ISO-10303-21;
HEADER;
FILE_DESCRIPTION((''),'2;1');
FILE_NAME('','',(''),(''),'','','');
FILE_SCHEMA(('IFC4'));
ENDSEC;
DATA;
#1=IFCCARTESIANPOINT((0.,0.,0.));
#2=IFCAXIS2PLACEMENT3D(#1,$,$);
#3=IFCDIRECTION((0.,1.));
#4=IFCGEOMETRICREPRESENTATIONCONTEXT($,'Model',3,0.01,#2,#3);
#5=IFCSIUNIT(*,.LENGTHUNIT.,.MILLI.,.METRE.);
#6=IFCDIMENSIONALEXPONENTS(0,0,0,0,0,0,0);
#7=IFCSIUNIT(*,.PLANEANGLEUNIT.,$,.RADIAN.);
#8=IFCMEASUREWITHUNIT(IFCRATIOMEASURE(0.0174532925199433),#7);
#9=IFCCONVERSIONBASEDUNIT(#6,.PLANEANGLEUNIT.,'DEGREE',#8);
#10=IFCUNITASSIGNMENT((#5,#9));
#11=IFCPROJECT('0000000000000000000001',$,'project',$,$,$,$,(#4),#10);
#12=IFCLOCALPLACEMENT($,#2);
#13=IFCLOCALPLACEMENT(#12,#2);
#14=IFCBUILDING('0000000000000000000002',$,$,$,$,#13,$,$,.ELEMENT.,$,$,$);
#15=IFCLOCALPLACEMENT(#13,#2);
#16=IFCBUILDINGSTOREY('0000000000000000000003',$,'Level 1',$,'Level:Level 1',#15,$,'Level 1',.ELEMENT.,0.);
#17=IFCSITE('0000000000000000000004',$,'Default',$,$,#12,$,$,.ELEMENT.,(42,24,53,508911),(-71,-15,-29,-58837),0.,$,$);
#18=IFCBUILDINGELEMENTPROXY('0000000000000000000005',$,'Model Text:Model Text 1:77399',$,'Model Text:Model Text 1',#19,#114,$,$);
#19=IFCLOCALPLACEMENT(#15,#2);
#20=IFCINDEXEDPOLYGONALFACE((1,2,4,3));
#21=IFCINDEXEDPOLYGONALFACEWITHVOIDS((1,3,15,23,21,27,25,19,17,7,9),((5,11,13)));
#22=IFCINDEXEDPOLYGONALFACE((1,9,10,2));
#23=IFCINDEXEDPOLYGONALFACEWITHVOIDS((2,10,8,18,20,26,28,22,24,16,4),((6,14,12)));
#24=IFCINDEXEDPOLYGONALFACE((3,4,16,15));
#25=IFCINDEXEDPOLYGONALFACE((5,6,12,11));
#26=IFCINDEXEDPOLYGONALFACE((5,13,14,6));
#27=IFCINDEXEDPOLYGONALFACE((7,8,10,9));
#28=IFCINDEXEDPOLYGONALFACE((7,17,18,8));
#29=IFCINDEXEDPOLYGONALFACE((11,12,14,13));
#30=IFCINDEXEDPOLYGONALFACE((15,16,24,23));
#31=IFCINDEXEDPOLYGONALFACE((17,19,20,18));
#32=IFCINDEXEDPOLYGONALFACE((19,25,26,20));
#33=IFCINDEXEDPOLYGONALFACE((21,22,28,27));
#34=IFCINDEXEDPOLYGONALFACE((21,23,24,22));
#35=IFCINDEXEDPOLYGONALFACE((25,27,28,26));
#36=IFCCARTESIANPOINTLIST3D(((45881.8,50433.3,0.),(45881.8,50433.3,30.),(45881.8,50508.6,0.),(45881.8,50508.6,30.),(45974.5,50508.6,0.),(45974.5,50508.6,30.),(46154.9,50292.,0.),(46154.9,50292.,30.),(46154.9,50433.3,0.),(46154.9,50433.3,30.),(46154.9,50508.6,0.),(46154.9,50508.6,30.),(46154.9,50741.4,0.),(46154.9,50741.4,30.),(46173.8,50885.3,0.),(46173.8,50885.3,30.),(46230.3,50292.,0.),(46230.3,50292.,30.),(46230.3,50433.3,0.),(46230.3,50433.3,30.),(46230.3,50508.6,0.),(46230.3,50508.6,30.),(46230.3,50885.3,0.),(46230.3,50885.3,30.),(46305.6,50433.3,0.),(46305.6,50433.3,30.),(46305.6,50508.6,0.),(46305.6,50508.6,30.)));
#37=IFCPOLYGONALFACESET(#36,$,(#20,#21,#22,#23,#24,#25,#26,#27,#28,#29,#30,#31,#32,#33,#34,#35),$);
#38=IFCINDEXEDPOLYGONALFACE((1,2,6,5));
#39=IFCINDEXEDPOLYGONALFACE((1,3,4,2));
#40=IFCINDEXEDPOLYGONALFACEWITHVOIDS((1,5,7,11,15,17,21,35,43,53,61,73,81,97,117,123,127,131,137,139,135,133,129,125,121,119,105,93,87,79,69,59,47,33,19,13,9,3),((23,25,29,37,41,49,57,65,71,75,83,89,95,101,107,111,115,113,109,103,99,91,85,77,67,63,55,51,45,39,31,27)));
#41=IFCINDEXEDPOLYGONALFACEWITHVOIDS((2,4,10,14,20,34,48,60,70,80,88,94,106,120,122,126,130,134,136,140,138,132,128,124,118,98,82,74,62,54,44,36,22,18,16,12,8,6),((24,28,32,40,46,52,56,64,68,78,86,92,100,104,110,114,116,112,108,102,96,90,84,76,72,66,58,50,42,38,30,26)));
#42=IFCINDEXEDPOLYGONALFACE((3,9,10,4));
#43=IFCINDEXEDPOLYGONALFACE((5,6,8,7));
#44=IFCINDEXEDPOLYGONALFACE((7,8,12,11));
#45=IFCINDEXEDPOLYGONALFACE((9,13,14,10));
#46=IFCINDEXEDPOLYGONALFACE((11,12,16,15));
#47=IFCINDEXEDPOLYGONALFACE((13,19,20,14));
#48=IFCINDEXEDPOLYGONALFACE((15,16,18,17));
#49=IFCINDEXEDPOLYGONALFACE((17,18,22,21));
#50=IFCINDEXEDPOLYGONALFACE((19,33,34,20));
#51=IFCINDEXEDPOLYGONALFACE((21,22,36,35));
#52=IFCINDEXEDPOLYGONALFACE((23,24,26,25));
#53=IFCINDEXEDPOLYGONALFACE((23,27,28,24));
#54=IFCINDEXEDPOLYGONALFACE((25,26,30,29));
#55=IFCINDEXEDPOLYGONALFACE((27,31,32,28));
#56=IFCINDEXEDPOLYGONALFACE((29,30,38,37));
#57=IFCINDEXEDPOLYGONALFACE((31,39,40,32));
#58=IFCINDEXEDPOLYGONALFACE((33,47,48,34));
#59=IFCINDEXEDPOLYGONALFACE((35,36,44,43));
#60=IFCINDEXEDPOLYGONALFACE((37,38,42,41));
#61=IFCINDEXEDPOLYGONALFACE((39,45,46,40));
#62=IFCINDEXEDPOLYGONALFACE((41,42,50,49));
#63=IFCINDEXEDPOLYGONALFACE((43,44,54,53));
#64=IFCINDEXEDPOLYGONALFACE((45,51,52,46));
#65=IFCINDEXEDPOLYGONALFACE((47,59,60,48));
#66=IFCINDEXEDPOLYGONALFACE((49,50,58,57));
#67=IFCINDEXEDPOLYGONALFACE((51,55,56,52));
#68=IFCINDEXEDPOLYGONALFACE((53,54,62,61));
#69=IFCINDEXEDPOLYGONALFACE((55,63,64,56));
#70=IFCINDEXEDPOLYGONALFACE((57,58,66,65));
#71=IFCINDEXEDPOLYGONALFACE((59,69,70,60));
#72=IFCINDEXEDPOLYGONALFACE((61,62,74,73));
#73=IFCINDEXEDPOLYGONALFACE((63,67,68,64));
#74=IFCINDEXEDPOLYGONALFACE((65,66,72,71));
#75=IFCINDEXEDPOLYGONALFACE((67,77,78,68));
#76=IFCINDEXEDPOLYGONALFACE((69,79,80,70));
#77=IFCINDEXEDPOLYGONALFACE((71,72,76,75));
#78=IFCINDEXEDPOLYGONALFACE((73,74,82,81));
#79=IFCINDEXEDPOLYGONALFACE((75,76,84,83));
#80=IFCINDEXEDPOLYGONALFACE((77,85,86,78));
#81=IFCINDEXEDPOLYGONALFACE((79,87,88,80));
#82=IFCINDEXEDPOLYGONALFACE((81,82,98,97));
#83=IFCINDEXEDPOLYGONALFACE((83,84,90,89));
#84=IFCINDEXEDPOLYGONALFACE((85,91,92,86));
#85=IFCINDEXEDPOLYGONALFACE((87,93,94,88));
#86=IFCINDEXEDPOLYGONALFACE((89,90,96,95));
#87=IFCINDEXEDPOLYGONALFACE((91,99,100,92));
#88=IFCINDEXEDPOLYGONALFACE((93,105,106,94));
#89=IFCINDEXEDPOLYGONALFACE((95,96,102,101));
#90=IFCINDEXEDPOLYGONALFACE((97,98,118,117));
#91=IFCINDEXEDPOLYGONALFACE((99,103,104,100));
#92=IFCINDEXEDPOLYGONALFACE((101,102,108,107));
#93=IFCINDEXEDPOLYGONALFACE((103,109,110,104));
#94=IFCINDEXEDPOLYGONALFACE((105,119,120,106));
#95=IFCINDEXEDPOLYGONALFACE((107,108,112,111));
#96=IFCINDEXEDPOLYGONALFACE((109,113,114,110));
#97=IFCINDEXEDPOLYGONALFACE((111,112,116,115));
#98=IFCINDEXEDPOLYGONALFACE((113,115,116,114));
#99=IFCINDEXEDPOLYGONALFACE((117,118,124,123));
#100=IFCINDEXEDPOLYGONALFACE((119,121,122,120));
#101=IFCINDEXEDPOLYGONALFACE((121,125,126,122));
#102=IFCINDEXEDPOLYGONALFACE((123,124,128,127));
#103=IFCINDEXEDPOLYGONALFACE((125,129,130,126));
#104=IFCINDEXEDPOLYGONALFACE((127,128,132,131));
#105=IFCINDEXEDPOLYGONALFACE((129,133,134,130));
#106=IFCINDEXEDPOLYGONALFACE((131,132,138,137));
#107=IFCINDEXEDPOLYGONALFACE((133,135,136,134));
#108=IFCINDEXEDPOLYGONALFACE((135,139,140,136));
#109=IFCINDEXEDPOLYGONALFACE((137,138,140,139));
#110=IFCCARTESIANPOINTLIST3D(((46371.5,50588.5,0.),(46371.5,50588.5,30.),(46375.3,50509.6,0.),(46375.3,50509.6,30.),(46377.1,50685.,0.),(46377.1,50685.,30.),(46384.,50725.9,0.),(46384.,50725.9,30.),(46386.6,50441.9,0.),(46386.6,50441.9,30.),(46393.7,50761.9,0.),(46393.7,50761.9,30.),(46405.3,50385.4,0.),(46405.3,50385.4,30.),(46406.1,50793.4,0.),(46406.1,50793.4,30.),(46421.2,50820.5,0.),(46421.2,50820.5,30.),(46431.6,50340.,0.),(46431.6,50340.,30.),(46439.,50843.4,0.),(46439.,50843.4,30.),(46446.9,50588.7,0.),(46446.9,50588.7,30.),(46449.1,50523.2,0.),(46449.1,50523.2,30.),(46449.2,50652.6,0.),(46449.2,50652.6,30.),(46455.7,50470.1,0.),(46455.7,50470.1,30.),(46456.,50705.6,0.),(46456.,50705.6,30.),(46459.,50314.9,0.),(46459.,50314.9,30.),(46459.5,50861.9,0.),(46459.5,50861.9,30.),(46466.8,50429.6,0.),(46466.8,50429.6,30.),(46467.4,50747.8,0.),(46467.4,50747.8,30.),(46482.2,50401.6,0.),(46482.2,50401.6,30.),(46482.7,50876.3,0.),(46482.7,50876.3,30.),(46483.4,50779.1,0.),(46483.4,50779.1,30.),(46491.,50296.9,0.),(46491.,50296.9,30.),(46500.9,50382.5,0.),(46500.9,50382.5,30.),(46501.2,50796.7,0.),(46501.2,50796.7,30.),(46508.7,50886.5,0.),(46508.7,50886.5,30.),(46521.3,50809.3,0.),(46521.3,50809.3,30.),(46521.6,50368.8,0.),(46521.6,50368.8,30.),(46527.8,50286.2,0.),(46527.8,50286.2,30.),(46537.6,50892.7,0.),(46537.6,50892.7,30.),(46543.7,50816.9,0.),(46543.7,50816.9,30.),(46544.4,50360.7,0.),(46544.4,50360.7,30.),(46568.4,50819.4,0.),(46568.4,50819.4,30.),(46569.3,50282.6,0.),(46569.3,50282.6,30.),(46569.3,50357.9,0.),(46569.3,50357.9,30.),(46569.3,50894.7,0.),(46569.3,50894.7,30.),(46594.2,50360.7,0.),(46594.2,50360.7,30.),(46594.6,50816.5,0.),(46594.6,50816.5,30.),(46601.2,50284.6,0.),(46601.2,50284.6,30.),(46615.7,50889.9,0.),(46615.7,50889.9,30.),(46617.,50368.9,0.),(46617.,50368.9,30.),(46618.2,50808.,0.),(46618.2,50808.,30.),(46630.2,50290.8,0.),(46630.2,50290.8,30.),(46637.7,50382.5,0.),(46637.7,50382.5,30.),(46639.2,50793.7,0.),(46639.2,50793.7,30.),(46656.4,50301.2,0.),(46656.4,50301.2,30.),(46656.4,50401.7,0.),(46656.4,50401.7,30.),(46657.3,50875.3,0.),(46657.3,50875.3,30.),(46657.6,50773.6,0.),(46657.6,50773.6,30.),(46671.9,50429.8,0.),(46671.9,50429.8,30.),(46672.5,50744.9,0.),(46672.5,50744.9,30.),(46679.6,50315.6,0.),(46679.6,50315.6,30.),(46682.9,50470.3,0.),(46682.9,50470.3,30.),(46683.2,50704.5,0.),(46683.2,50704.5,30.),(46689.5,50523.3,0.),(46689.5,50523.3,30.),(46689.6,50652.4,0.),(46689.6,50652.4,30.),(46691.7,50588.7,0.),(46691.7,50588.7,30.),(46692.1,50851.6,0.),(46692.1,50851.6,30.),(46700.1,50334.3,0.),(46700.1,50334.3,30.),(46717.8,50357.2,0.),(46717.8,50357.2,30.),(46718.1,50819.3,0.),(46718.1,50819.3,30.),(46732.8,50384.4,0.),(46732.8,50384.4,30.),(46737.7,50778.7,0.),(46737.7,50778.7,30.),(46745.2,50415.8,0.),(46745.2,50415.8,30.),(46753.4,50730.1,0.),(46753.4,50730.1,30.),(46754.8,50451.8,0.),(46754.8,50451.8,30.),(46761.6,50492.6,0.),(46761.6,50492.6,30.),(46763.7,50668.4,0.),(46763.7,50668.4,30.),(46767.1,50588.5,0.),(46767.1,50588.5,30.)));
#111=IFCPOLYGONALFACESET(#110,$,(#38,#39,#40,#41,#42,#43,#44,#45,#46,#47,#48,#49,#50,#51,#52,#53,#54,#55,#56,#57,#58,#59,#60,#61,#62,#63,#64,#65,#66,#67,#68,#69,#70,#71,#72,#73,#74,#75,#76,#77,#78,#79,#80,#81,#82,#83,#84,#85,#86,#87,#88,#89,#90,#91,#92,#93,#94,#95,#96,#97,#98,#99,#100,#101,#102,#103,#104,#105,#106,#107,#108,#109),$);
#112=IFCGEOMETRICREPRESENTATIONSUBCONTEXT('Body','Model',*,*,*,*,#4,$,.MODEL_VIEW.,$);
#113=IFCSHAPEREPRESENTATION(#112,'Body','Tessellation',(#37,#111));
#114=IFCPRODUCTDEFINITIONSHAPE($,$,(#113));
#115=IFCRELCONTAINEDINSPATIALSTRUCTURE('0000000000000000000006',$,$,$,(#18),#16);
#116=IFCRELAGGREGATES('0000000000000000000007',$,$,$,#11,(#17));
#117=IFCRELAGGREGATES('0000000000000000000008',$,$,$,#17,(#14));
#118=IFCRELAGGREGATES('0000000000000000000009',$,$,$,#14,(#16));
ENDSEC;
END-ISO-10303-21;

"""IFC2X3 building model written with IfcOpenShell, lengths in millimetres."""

from ifc_helpers import new_model, entity, si_unit, converted_unit, direction, frame, origin, place, context, subcontext, project, spatial, polyline, outline, extrude, element, save


model = new_model("IFC2X3")

# Units and contexts
model_context = context("Model", 3, precision=0.01, world=origin(), true_north=direction((0.0, 1.0)))
body_context = subcontext(model_context, "Body", "Model", "MODEL_VIEW")
ifc_project = project(units=[si_unit("LENGTHUNIT", "METRE", prefix="MILLI"), converted_unit("PLANEANGLEUNIT", "DEGREE", entity("IfcRatioMeasure", 0.0174532925199433), si_unit("PLANEANGLEUNIT", "RADIAN"), dimensions=[0, 0, 0, 0, 0, 0, 0])], contexts=[model_context])

# Site, building, storey
site_placement = place(None, origin())
site = spatial("IfcSite", under=ifc_project, at=site_placement, Name="Default", CompositionType="ELEMENT", RefLatitude=(42, 24, 53, 508911), RefLongitude=(-71, -15, -29, -58837), RefElevation=0.0)
building_placement = place(site_placement, origin())
building = spatial("IfcBuilding", under=site, at=building_placement, CompositionType="ELEMENT")
storey_placement = place(building_placement, origin())
storey = spatial("IfcBuildingStorey", under=building, at=storey_placement, Name="Level 1", ObjectType="Level:Level 1", LongName="Level 1", CompositionType="ELEMENT", Elevation=0.0)

# Building element proxy
proxy_1_placement = place(storey_placement, origin())
element("IfcBuildingElementProxy", 1, at=proxy_1_placement, inside=storey, Name="Model Text:Model Text 1:77399", ObjectType="Model Text:Model Text 1", context=body_context, shape_type="SweptSolid", body=[
    extrude(outline(polyline([(-6.8, -218.3), (68.5, -218.3), (68.5, -77.1), (143.8, -77.1), (143.8, -1.7), (68.5, -1.7), (68.5, 375.0), (12.0, 375.0), (-280.0, -1.7), (-280.0, -77.1), (-6.8, -77.1), (-6.8, -218.3)]), holes=[polyline([(-6.8, -1.7), (-187.3, -1.7), (-6.8, 231.1), (-6.8, -1.7)])]), frame((46161.8, 50510.3, 0.0)), (0.0, 0.0, 1.0), 30.0),
    extrude(outline(polyline([(-10.6, -198.7), (68.3, -198.7), (136.5, -190.7), (193.9, -174.7), (240.5, -150.6), (266.9, -124.4), (286.3, -93.2), (298.8, -57.0), (304.3, -15.7), (303.8, 16.2), (299.0, 45.5), (289.9, 72.1), (276.6, 96.0), (258.9, 117.3), (236.9, 136.2), (210.4, 152.5), (179.6, 166.3), (144.1, 177.6), (103.7, 186.3), (8.2, 196.4), (-71.8, 196.7), (-134.0, 189.4), (-183.3, 176.1), (-224.7, 158.4), (-258.2, 133.9), (-283.5, 100.3), (-300.1, 59.5), (-307.1, 13.4), (-306.6, -18.4), (-301.8, -47.5), (-292.8, -74.0), (-279.6, -97.9), (-262.0, -119.2), (-240.0, -138.1), (-213.6, -154.5), (-182.8, -168.4), (-147.3, -179.8), (-106.7, -188.6), (-10.6, -198.7)]), holes=[polyline([(-7.2, -123.5), (-71.0, -118.2), (-123.6, -108.8), (-165.2, -95.4), (-195.7, -78.0), (-212.4, -59.4), (-224.1, -38.7), (-230.6, -15.9), (-231.9, 8.9), (-227.8, 35.0), (-218.1, 58.1), (-202.8, 78.4), (-182.0, 95.8), (-152.6, 109.4), (-111.7, 118.1), (-59.4, 122.0), (4.4, 121.1), (69.6, 115.8), (122.2, 106.7), (162.2, 93.7), (189.5, 77.0), (207.7, 57.4), (220.4, 36.0), (227.5, 12.8), (229.1, -12.1), (225.2, -36.8), (215.9, -59.2), (201.3, -79.3), (181.4, -97.1), (152.6, -111.2), (111.6, -120.3), (58.3, -124.4), (-7.2, -123.5)])]), frame((46570.6, 50587.3, 0.0), z_axis=(0.0, 0.0, 1.0), x_axis=(0.047515, -0.998871, 0.0)), (0.0, 0.0, 1.0), 30.0),
])

save(model, "model.ifc")
